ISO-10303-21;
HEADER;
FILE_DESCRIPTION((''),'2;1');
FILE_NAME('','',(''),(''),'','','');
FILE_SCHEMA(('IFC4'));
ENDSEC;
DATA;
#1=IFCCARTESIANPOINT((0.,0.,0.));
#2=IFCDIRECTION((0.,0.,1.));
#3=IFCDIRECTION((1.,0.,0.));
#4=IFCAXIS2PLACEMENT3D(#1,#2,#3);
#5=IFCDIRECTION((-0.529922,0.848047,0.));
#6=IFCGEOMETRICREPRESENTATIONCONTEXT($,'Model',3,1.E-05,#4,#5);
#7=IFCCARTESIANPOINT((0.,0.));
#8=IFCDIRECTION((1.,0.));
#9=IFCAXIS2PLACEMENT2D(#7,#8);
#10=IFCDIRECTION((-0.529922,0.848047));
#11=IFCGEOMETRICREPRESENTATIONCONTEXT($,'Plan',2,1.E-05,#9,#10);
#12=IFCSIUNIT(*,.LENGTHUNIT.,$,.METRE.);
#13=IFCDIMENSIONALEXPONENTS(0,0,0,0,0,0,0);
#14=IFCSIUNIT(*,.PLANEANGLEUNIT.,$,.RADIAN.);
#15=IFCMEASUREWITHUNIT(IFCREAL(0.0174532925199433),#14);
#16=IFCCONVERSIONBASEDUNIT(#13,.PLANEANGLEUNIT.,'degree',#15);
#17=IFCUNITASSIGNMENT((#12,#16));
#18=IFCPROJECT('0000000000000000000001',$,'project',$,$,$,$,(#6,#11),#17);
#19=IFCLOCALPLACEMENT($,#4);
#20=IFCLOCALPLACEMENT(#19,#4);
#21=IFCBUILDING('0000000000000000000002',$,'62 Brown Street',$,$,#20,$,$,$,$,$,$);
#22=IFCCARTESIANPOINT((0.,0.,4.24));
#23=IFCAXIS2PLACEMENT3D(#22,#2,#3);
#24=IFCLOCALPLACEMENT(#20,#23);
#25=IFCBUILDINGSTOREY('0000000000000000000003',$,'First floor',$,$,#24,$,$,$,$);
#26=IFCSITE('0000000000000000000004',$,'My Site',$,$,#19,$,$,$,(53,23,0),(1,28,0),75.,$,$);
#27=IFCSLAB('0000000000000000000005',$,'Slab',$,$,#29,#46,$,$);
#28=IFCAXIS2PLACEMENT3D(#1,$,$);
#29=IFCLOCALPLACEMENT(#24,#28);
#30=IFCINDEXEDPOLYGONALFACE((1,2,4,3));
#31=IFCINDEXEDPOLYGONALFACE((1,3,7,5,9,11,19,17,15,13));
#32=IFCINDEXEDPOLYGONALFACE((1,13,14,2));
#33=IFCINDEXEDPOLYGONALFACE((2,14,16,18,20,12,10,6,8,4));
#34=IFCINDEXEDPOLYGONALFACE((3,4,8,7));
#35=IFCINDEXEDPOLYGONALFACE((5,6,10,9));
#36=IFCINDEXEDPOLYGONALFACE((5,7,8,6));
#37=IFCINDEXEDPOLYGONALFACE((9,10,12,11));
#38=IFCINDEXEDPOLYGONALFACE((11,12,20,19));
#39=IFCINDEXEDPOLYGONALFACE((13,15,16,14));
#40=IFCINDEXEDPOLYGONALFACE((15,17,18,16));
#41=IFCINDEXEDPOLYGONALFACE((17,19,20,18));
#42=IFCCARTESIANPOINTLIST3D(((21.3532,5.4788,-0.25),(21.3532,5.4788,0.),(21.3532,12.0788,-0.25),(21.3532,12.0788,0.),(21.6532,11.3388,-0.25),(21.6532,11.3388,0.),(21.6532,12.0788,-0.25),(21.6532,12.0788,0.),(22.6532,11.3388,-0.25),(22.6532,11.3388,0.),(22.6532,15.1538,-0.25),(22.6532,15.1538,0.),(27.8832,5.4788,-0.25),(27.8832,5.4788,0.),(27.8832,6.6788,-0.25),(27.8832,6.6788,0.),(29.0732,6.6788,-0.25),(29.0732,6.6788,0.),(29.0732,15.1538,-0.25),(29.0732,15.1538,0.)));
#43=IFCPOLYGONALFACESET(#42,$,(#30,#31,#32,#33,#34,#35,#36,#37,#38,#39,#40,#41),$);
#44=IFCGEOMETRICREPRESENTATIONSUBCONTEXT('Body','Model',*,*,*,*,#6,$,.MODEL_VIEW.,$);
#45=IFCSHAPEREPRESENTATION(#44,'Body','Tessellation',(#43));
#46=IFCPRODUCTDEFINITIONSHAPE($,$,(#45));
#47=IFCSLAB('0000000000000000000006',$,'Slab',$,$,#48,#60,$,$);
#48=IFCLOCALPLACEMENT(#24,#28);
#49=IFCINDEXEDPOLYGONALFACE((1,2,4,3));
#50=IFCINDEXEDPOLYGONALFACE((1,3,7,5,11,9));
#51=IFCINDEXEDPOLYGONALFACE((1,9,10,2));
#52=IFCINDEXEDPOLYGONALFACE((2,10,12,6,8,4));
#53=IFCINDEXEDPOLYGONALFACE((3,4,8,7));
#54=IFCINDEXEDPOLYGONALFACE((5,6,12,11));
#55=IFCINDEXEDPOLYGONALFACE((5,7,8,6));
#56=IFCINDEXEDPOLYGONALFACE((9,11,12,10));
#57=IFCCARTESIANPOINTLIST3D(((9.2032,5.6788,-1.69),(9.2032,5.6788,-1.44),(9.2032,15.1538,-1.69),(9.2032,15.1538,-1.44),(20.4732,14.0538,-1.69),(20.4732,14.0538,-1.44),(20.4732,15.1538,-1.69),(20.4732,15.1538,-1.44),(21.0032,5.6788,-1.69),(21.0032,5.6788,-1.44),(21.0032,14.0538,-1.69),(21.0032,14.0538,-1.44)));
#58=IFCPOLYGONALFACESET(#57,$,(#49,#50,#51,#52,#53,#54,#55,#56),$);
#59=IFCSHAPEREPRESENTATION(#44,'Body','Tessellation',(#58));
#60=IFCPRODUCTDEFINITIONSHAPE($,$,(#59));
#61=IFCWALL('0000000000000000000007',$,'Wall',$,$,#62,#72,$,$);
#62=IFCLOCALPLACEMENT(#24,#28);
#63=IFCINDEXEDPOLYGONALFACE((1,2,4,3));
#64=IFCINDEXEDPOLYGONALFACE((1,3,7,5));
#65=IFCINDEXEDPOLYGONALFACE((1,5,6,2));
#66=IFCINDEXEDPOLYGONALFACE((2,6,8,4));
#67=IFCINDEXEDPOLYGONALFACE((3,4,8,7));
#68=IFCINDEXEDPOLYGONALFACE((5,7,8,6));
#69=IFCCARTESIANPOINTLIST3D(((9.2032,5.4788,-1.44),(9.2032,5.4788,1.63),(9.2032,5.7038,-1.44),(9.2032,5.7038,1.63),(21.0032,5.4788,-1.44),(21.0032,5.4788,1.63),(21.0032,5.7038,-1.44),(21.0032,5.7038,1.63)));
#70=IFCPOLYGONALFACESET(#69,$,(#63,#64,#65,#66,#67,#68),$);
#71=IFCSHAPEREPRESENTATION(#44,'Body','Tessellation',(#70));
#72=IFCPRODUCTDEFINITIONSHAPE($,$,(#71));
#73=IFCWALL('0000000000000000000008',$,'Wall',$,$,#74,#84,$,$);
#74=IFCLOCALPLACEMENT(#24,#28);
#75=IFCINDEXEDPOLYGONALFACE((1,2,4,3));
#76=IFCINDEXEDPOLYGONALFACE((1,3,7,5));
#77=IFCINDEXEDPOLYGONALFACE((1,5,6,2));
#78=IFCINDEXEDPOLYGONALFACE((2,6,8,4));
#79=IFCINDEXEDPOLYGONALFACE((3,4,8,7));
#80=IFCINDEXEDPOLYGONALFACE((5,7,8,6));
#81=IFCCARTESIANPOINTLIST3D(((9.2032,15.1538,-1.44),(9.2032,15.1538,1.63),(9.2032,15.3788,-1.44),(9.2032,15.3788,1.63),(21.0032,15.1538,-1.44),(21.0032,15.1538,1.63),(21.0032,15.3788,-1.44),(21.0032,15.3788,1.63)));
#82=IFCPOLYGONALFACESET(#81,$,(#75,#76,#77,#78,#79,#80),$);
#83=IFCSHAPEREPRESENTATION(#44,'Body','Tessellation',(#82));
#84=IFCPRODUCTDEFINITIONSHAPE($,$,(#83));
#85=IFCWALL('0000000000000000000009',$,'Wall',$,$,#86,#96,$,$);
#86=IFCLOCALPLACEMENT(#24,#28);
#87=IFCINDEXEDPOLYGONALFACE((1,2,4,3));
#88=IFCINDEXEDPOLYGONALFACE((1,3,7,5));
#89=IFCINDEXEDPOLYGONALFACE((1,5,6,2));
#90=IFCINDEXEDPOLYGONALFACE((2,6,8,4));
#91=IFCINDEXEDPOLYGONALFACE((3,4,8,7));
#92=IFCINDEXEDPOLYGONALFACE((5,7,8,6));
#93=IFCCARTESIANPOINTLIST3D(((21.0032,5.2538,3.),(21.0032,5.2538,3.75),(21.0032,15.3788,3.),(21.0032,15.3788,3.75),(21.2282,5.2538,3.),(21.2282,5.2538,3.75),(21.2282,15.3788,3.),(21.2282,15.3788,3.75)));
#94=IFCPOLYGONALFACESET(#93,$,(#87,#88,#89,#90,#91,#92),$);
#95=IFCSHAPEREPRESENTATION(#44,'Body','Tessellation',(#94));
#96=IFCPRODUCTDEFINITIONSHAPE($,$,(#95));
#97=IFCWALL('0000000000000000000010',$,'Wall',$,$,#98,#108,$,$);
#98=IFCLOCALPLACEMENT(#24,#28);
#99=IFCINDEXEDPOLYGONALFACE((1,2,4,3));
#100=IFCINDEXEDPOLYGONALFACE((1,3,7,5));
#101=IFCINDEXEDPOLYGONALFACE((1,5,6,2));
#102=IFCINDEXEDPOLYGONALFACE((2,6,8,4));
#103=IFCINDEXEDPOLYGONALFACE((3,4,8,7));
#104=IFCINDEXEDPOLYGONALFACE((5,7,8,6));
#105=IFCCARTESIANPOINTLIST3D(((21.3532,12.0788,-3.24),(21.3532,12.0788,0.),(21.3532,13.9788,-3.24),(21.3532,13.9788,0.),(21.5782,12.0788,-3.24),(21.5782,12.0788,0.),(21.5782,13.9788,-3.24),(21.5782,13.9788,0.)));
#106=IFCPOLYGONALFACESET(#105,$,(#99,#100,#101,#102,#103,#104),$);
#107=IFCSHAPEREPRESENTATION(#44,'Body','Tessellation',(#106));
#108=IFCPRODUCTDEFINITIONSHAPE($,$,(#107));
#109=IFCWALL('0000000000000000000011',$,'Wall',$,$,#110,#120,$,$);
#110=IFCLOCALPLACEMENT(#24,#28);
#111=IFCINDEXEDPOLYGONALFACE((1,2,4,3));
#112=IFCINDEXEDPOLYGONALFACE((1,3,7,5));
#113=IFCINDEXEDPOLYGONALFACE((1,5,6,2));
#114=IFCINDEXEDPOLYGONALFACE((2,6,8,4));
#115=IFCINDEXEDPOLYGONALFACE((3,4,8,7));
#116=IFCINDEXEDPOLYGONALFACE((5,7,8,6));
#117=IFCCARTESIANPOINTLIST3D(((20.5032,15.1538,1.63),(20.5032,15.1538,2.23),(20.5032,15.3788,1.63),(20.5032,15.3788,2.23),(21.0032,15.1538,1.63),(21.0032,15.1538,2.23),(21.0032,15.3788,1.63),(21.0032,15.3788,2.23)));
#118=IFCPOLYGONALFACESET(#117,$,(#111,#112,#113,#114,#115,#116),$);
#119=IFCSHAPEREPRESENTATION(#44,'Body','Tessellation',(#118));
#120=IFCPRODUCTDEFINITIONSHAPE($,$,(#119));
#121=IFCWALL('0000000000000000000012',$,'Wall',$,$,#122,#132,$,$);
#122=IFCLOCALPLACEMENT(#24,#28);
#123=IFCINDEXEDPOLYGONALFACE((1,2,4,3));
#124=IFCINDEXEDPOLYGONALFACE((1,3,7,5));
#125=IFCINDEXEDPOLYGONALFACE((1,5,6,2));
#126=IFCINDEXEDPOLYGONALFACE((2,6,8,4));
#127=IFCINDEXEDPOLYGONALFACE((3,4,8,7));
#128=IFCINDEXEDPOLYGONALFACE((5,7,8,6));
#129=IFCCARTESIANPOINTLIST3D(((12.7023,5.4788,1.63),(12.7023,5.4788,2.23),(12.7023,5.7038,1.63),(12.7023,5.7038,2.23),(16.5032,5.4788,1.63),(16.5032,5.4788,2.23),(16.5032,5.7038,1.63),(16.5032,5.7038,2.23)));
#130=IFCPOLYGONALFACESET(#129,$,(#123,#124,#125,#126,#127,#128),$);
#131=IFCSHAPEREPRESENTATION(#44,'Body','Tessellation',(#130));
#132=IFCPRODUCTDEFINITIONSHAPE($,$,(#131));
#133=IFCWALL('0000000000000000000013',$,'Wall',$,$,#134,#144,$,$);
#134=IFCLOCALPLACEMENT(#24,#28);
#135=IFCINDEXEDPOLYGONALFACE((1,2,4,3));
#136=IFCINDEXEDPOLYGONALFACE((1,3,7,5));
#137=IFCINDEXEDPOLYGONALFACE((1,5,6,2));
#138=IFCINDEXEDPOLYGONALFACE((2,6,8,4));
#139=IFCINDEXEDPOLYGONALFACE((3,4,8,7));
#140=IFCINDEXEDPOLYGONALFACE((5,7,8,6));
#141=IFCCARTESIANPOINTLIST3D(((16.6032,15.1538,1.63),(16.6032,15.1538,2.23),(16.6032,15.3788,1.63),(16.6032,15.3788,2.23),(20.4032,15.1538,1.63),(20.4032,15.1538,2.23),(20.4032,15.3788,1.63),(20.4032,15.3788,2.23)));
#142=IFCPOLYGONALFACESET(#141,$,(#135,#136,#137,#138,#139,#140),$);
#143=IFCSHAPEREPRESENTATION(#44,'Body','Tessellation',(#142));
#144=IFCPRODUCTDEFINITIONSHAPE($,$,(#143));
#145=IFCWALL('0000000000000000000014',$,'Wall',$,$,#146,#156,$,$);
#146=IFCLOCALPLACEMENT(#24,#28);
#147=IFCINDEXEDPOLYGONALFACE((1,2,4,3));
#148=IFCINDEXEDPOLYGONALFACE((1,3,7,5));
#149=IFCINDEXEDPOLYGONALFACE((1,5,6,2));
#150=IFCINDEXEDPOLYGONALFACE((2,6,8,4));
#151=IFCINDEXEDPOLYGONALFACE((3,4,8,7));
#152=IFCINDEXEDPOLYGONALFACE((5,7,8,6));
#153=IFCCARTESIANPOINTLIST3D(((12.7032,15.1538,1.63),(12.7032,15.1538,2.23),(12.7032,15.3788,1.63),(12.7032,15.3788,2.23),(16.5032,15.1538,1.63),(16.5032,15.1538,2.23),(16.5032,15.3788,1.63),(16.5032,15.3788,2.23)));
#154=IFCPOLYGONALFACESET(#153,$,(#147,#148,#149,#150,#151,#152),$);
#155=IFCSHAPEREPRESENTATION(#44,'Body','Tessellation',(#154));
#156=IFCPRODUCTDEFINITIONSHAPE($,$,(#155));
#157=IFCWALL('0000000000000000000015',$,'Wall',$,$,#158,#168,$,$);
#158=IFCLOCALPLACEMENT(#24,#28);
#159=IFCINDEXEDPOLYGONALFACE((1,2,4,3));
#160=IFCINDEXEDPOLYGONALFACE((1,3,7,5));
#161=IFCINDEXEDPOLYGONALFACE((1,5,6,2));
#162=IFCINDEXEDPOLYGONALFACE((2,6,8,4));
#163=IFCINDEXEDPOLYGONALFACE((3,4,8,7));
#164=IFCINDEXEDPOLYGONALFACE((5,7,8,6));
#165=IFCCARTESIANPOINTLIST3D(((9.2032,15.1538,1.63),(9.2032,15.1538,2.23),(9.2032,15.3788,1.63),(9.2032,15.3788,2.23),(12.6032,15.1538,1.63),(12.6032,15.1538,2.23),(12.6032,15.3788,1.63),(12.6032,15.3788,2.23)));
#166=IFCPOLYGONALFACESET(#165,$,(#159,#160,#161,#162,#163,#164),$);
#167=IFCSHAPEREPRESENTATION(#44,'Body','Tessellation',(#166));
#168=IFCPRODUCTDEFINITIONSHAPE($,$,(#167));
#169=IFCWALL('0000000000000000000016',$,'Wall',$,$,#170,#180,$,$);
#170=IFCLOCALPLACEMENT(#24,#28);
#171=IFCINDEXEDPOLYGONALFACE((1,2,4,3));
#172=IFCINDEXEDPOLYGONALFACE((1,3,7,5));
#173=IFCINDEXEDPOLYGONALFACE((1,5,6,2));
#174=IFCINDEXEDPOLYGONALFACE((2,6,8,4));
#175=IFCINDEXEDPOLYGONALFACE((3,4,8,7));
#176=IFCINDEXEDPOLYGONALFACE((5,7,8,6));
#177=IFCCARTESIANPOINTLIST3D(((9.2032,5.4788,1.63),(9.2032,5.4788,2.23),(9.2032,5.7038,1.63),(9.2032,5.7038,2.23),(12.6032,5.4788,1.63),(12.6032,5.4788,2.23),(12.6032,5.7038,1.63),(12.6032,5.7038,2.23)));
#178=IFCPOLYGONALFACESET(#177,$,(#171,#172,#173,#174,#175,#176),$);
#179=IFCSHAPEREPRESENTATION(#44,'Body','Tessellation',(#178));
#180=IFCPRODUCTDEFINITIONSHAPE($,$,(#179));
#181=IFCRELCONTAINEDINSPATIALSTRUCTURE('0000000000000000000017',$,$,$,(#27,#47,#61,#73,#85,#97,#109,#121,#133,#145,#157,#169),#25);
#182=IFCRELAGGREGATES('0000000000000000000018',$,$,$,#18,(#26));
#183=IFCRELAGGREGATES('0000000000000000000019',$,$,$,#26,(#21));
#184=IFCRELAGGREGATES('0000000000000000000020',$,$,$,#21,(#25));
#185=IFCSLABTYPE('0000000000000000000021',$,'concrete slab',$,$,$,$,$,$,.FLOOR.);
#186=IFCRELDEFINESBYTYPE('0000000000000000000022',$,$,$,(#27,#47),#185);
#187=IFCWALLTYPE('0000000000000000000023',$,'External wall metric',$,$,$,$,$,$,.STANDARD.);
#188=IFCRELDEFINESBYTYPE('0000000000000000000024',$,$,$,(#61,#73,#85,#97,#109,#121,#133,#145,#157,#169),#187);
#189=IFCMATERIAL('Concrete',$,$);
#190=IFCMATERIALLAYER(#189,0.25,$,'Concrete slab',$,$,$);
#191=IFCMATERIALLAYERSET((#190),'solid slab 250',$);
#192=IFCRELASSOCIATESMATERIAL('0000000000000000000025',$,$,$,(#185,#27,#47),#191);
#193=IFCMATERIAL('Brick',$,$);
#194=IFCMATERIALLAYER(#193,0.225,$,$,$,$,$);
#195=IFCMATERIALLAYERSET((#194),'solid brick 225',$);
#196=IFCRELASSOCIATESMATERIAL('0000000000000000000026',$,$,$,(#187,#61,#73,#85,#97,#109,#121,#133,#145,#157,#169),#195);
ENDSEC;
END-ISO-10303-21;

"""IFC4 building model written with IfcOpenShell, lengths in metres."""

from ifc_helpers import new_model, entity, si_unit, converted_unit, direction, frame, origin_with_axes, origin_2d_with_axis, place, context, subcontext, project, spatial, line, indexed_curve, outline, extrude, material, layer, layer_set, layer_usage, type_object, element, save


model = new_model("IFC4")

# Units and contexts
model_context = context("Model", 3, precision=1e-05, world=origin_with_axes(), true_north=direction((-0.529922, 0.848047, 0.0)))
plan_context = context("Plan", 2, precision=1e-05, world=origin_2d_with_axis(), true_north=direction((-0.529922, 0.848047)))
body_context = subcontext(model_context, "Body", "Model", "MODEL_VIEW")
ifc_project = project(units=[si_unit("LENGTHUNIT", "METRE"), converted_unit("PLANEANGLEUNIT", "degree", entity("IfcReal", 0.0174532925199433), si_unit("PLANEANGLEUNIT", "RADIAN"), dimensions=[0, 0, 0, 0, 0, 0, 0])], contexts=[model_context, plan_context])

# Site, building, storey
site_placement = place(None, origin_with_axes())
site = spatial("IfcSite", under=ifc_project, at=site_placement, Name="My Site", RefLatitude=(53, 23, 0), RefLongitude=(1, 28, 0), RefElevation=75.0)
building_placement = place(site_placement, origin_with_axes())
building = spatial("IfcBuilding", under=site, at=building_placement, Name="62 Brown Street")
storey_placement = place(building_placement, frame((0.0, 0.0, 4.24), z_axis=(0.0, 0.0, 1.0), x_axis=(1.0, 0.0, 0.0)))
storey = spatial("IfcBuildingStorey", under=building, at=storey_placement, Name="First floor")

# Shared definitions
ifc_material_1 = material(Name="Concrete")

# Slabs
ifc_layer_1 = layer(ifc_material_1, 0.25, Name="Concrete slab")
ifc_layer_set_1 = layer_set([ifc_layer_1], Name="solid slab 250")
ifc_layer_usage_1 = layer_usage(ifc_layer_set_1, "AXIS3", "POSITIVE", 0.0)
slab_type = type_object("IfcSlabType", Name="concrete slab", PredefinedType="FLOOR", material=ifc_layer_set_1)
slab_1_placement = place(storey_placement, frame((21.3532, 5.4788, -0.25), z_axis=(0.0, 0.0, 1.0), x_axis=(1.0, 0.0, 0.0)))
element("IfcSlab", 1, at=slab_1_placement, inside=storey, type_object=slab_type, material=ifc_layer_usage_1, Name="Slab", context=body_context, shape_type="SweptSolid", body=[
    extrude(outline(indexed_curve([(6.53, 1.2), (6.53, 0.0), (0.0, 0.0), (0.0, 6.6), (0.3, 6.6), (0.3, 5.86), (1.3, 5.86), (1.3, 9.675), (7.72, 9.675), (7.72, 1.2), (6.53, 1.2)])), None, (0.0, 0.0, 1.0), 0.25),
])
ifc_layer_usage_2 = layer_usage(ifc_layer_set_1, "AXIS3", "POSITIVE", 0.0)
slab_2_placement = place(storey_placement, frame((9.2032, 5.6788, -1.69), z_axis=(0.0, 0.0, 1.0), x_axis=(1.0, 0.0, 0.0)))
element("IfcSlab", 2, at=slab_2_placement, inside=storey, type_object=slab_type, material=ifc_layer_usage_2, Name="Slab", context=body_context, shape_type="SweptSolid", body=[
    extrude(outline(indexed_curve([(11.27, 9.475), (11.8, 0.0), (0.0, 0.0), (0.0, 9.475), (11.8, 8.375), (11.27, 8.375)], segments=[line(6, 1), line(1, 4), line(4, 3), line(3, 2), line(2, 5), line(5, 6)], self_intersect=False)), None, (0.0, 0.0, 1.0), 0.25),
])

# Walls
ifc_material_2 = material(Name="Brick")
ifc_layer_2 = layer(ifc_material_2, 0.225)
ifc_layer_set_2 = layer_set([ifc_layer_2], Name="solid brick 225")
ifc_layer_usage_3 = layer_usage(ifc_layer_set_2, "AXIS2", "POSITIVE", 0.0)
wall_type_1 = type_object("IfcWallType", Name="External wall metric", PredefinedType="STANDARD", material=ifc_layer_set_2)
wall_1_placement = place(storey_placement, frame((9.2032, 5.4788, -1.44), z_axis=(0.0, 0.0, 1.0), x_axis=(1.0, 0.0, 0.0)))
element("IfcWall", 3, at=wall_1_placement, inside=storey, type_object=wall_type_1, material=ifc_layer_usage_3, Name="Wall", context=body_context, shape_type="SweptSolid", body=[
    extrude(outline(indexed_curve([(0.0, 0.0), (0.0, 0.225), (11.8, 0.225), (11.8, 0.0), (0.0, 0.0)], self_intersect=False)), origin_with_axes(), (0.0, 0.0, 1.0), 3.07),
])
ifc_layer_usage_4 = layer_usage(ifc_layer_set_2, "AXIS2", "POSITIVE", 0.0)
wall_2_placement = place(storey_placement, frame((21.0032, 15.3788, -1.44), z_axis=(0.0, 0.0, 1.0), x_axis=(-1.0, 0.0, 0.0)))
element("IfcWall", 4, at=wall_2_placement, inside=storey, type_object=wall_type_1, material=ifc_layer_usage_4, Name="Wall", context=body_context, shape_type="SweptSolid", body=[
    extrude(outline(indexed_curve([(0.0, 0.0), (0.0, 0.225), (11.8, 0.225), (11.8, 0.0), (0.0, 0.0)], self_intersect=False)), origin_with_axes(), (0.0, 0.0, 1.0), 3.07),
])
ifc_layer_usage_5 = layer_usage(ifc_layer_set_2, "AXIS2", "POSITIVE", 0.0)
wall_3_placement = place(storey_placement, frame((21.0032, 15.3788, 3.0), z_axis=(0.0, 0.0, 1.0), x_axis=(0.0, -1.0, 0.0)))
element("IfcWall", 5, at=wall_3_placement, inside=storey, type_object=wall_type_1, material=ifc_layer_usage_5, Name="Wall", context=body_context, shape_type="SweptSolid", body=[
    extrude(outline(indexed_curve([(0.0, 0.0), (0.0, 0.225), (10.125, 0.225), (10.125, 0.0), (0.0, 0.0)], self_intersect=False)), origin_with_axes(), (0.0, 0.0, 1.0), 0.75),
])
ifc_layer_usage_6 = layer_usage(ifc_layer_set_2, "AXIS2", "POSITIVE", 0.0)
wall_4_placement = place(storey_placement, frame((21.3532, 13.9788, -3.24), z_axis=(0.0, 0.0, 1.0), x_axis=(0.0, -1.0, 0.0)))
element("IfcWall", 6, at=wall_4_placement, inside=storey, type_object=wall_type_1, material=ifc_layer_usage_6, Name="Wall", context=body_context, shape_type="SweptSolid", body=[
    extrude(outline(indexed_curve([(0.0, 0.0), (0.0, 0.225), (1.9, 0.225), (1.9, 0.0), (0.0, 0.0)], self_intersect=False)), origin_with_axes(), (0.0, 0.0, 1.0), 3.24),
])
ifc_layer_usage_7 = layer_usage(ifc_layer_set_2, "AXIS2", "POSITIVE", 0.0)
wall_5_placement = place(storey_placement, frame((21.0032, 15.3788, 1.63), z_axis=(0.0, 0.0, 1.0), x_axis=(-1.0, 0.0, 0.0)))
element("IfcWall", 7, at=wall_5_placement, inside=storey, type_object=wall_type_1, material=ifc_layer_usage_7, Name="Wall", context=body_context, shape_type="SweptSolid", body=[
    extrude(outline(indexed_curve([(0.0, 0.0), (0.0, 0.225), (0.5, 0.225), (0.5, 0.0), (0.0, 0.0)], self_intersect=False)), origin_with_axes(), (0.0, 0.0, 1.0), 0.6),
])
ifc_layer_usage_8 = layer_usage(ifc_layer_set_2, "AXIS2", "POSITIVE", 0.0)
wall_6_placement = place(storey_placement, frame((12.7023, 5.4788, 1.63), z_axis=(0.0, 0.0, 1.0), x_axis=(1.0, 0.0, 0.0)))
element("IfcWall", 8, at=wall_6_placement, inside=storey, type_object=wall_type_1, material=ifc_layer_usage_8, Name="Wall", context=body_context, shape_type="SweptSolid", body=[
    extrude(outline(indexed_curve([(0.0, 0.0), (0.0, 0.225), (3.8009, 0.225), (3.8009, 0.0), (0.0, 0.0)], self_intersect=False)), origin_with_axes(), (0.0, 0.0, 1.0), 0.6),
])
ifc_layer_usage_9 = layer_usage(ifc_layer_set_2, "AXIS2", "POSITIVE", 0.0)
wall_7_placement = place(storey_placement, frame((20.4032, 15.3788, 1.63), z_axis=(0.0, 0.0, 1.0), x_axis=(-1.0, 0.0, 0.0)))
element("IfcWall", 9, at=wall_7_placement, inside=storey, type_object=wall_type_1, material=ifc_layer_usage_9, Name="Wall", context=body_context, shape_type="SweptSolid", body=[
    extrude(outline(indexed_curve([(0.0, 0.0), (0.0, 0.225), (3.8, 0.225), (3.8, 0.0), (0.0, 0.0)], self_intersect=False)), origin_with_axes(), (0.0, 0.0, 1.0), 0.6),
])
ifc_layer_usage_10 = layer_usage(ifc_layer_set_2, "AXIS2", "POSITIVE", 0.0)
wall_8_placement = place(storey_placement, frame((16.5032, 15.3788, 1.63), z_axis=(0.0, 0.0, 1.0), x_axis=(-1.0, 0.0, 0.0)))
element("IfcWall", 10, at=wall_8_placement, inside=storey, type_object=wall_type_1, material=ifc_layer_usage_10, Name="Wall", context=body_context, shape_type="SweptSolid", body=[
    extrude(outline(indexed_curve([(0.0, 0.0), (0.0, 0.225), (3.8, 0.225), (3.8, 0.0), (0.0, 0.0)], self_intersect=False)), origin_with_axes(), (0.0, 0.0, 1.0), 0.6),
])
ifc_layer_usage_11 = layer_usage(ifc_layer_set_2, "AXIS2", "POSITIVE", 0.0)
wall_9_placement = place(storey_placement, frame((12.6032, 15.3788, 1.63), z_axis=(0.0, 0.0, 1.0), x_axis=(-1.0, 0.0, 0.0)))
element("IfcWall", 11, at=wall_9_placement, inside=storey, type_object=wall_type_1, material=ifc_layer_usage_11, Name="Wall", context=body_context, shape_type="SweptSolid", body=[
    extrude(outline(indexed_curve([(0.0, 0.0), (0.0, 0.225), (3.4, 0.225), (3.4, 0.0), (0.0, 0.0)], self_intersect=False)), origin_with_axes(), (0.0, 0.0, 1.0), 0.6),
])
ifc_layer_usage_12 = layer_usage(ifc_layer_set_2, "AXIS2", "POSITIVE", 0.0)
wall_10_placement = place(storey_placement, frame((9.2032, 5.4788, 1.63), z_axis=(0.0, 0.0, 1.0), x_axis=(1.0, 0.0, 0.0)))
element("IfcWall", 12, at=wall_10_placement, inside=storey, type_object=wall_type_1, material=ifc_layer_usage_12, Name="Wall", context=body_context, shape_type="SweptSolid", body=[
    extrude(outline(indexed_curve([(0.0, 0.0), (0.0, 0.225), (3.4, 0.225), (3.4, 0.0), (0.0, 0.0)], self_intersect=False)), origin_with_axes(), (0.0, 0.0, 1.0), 0.6),
])

save(model, "model.ifc")
